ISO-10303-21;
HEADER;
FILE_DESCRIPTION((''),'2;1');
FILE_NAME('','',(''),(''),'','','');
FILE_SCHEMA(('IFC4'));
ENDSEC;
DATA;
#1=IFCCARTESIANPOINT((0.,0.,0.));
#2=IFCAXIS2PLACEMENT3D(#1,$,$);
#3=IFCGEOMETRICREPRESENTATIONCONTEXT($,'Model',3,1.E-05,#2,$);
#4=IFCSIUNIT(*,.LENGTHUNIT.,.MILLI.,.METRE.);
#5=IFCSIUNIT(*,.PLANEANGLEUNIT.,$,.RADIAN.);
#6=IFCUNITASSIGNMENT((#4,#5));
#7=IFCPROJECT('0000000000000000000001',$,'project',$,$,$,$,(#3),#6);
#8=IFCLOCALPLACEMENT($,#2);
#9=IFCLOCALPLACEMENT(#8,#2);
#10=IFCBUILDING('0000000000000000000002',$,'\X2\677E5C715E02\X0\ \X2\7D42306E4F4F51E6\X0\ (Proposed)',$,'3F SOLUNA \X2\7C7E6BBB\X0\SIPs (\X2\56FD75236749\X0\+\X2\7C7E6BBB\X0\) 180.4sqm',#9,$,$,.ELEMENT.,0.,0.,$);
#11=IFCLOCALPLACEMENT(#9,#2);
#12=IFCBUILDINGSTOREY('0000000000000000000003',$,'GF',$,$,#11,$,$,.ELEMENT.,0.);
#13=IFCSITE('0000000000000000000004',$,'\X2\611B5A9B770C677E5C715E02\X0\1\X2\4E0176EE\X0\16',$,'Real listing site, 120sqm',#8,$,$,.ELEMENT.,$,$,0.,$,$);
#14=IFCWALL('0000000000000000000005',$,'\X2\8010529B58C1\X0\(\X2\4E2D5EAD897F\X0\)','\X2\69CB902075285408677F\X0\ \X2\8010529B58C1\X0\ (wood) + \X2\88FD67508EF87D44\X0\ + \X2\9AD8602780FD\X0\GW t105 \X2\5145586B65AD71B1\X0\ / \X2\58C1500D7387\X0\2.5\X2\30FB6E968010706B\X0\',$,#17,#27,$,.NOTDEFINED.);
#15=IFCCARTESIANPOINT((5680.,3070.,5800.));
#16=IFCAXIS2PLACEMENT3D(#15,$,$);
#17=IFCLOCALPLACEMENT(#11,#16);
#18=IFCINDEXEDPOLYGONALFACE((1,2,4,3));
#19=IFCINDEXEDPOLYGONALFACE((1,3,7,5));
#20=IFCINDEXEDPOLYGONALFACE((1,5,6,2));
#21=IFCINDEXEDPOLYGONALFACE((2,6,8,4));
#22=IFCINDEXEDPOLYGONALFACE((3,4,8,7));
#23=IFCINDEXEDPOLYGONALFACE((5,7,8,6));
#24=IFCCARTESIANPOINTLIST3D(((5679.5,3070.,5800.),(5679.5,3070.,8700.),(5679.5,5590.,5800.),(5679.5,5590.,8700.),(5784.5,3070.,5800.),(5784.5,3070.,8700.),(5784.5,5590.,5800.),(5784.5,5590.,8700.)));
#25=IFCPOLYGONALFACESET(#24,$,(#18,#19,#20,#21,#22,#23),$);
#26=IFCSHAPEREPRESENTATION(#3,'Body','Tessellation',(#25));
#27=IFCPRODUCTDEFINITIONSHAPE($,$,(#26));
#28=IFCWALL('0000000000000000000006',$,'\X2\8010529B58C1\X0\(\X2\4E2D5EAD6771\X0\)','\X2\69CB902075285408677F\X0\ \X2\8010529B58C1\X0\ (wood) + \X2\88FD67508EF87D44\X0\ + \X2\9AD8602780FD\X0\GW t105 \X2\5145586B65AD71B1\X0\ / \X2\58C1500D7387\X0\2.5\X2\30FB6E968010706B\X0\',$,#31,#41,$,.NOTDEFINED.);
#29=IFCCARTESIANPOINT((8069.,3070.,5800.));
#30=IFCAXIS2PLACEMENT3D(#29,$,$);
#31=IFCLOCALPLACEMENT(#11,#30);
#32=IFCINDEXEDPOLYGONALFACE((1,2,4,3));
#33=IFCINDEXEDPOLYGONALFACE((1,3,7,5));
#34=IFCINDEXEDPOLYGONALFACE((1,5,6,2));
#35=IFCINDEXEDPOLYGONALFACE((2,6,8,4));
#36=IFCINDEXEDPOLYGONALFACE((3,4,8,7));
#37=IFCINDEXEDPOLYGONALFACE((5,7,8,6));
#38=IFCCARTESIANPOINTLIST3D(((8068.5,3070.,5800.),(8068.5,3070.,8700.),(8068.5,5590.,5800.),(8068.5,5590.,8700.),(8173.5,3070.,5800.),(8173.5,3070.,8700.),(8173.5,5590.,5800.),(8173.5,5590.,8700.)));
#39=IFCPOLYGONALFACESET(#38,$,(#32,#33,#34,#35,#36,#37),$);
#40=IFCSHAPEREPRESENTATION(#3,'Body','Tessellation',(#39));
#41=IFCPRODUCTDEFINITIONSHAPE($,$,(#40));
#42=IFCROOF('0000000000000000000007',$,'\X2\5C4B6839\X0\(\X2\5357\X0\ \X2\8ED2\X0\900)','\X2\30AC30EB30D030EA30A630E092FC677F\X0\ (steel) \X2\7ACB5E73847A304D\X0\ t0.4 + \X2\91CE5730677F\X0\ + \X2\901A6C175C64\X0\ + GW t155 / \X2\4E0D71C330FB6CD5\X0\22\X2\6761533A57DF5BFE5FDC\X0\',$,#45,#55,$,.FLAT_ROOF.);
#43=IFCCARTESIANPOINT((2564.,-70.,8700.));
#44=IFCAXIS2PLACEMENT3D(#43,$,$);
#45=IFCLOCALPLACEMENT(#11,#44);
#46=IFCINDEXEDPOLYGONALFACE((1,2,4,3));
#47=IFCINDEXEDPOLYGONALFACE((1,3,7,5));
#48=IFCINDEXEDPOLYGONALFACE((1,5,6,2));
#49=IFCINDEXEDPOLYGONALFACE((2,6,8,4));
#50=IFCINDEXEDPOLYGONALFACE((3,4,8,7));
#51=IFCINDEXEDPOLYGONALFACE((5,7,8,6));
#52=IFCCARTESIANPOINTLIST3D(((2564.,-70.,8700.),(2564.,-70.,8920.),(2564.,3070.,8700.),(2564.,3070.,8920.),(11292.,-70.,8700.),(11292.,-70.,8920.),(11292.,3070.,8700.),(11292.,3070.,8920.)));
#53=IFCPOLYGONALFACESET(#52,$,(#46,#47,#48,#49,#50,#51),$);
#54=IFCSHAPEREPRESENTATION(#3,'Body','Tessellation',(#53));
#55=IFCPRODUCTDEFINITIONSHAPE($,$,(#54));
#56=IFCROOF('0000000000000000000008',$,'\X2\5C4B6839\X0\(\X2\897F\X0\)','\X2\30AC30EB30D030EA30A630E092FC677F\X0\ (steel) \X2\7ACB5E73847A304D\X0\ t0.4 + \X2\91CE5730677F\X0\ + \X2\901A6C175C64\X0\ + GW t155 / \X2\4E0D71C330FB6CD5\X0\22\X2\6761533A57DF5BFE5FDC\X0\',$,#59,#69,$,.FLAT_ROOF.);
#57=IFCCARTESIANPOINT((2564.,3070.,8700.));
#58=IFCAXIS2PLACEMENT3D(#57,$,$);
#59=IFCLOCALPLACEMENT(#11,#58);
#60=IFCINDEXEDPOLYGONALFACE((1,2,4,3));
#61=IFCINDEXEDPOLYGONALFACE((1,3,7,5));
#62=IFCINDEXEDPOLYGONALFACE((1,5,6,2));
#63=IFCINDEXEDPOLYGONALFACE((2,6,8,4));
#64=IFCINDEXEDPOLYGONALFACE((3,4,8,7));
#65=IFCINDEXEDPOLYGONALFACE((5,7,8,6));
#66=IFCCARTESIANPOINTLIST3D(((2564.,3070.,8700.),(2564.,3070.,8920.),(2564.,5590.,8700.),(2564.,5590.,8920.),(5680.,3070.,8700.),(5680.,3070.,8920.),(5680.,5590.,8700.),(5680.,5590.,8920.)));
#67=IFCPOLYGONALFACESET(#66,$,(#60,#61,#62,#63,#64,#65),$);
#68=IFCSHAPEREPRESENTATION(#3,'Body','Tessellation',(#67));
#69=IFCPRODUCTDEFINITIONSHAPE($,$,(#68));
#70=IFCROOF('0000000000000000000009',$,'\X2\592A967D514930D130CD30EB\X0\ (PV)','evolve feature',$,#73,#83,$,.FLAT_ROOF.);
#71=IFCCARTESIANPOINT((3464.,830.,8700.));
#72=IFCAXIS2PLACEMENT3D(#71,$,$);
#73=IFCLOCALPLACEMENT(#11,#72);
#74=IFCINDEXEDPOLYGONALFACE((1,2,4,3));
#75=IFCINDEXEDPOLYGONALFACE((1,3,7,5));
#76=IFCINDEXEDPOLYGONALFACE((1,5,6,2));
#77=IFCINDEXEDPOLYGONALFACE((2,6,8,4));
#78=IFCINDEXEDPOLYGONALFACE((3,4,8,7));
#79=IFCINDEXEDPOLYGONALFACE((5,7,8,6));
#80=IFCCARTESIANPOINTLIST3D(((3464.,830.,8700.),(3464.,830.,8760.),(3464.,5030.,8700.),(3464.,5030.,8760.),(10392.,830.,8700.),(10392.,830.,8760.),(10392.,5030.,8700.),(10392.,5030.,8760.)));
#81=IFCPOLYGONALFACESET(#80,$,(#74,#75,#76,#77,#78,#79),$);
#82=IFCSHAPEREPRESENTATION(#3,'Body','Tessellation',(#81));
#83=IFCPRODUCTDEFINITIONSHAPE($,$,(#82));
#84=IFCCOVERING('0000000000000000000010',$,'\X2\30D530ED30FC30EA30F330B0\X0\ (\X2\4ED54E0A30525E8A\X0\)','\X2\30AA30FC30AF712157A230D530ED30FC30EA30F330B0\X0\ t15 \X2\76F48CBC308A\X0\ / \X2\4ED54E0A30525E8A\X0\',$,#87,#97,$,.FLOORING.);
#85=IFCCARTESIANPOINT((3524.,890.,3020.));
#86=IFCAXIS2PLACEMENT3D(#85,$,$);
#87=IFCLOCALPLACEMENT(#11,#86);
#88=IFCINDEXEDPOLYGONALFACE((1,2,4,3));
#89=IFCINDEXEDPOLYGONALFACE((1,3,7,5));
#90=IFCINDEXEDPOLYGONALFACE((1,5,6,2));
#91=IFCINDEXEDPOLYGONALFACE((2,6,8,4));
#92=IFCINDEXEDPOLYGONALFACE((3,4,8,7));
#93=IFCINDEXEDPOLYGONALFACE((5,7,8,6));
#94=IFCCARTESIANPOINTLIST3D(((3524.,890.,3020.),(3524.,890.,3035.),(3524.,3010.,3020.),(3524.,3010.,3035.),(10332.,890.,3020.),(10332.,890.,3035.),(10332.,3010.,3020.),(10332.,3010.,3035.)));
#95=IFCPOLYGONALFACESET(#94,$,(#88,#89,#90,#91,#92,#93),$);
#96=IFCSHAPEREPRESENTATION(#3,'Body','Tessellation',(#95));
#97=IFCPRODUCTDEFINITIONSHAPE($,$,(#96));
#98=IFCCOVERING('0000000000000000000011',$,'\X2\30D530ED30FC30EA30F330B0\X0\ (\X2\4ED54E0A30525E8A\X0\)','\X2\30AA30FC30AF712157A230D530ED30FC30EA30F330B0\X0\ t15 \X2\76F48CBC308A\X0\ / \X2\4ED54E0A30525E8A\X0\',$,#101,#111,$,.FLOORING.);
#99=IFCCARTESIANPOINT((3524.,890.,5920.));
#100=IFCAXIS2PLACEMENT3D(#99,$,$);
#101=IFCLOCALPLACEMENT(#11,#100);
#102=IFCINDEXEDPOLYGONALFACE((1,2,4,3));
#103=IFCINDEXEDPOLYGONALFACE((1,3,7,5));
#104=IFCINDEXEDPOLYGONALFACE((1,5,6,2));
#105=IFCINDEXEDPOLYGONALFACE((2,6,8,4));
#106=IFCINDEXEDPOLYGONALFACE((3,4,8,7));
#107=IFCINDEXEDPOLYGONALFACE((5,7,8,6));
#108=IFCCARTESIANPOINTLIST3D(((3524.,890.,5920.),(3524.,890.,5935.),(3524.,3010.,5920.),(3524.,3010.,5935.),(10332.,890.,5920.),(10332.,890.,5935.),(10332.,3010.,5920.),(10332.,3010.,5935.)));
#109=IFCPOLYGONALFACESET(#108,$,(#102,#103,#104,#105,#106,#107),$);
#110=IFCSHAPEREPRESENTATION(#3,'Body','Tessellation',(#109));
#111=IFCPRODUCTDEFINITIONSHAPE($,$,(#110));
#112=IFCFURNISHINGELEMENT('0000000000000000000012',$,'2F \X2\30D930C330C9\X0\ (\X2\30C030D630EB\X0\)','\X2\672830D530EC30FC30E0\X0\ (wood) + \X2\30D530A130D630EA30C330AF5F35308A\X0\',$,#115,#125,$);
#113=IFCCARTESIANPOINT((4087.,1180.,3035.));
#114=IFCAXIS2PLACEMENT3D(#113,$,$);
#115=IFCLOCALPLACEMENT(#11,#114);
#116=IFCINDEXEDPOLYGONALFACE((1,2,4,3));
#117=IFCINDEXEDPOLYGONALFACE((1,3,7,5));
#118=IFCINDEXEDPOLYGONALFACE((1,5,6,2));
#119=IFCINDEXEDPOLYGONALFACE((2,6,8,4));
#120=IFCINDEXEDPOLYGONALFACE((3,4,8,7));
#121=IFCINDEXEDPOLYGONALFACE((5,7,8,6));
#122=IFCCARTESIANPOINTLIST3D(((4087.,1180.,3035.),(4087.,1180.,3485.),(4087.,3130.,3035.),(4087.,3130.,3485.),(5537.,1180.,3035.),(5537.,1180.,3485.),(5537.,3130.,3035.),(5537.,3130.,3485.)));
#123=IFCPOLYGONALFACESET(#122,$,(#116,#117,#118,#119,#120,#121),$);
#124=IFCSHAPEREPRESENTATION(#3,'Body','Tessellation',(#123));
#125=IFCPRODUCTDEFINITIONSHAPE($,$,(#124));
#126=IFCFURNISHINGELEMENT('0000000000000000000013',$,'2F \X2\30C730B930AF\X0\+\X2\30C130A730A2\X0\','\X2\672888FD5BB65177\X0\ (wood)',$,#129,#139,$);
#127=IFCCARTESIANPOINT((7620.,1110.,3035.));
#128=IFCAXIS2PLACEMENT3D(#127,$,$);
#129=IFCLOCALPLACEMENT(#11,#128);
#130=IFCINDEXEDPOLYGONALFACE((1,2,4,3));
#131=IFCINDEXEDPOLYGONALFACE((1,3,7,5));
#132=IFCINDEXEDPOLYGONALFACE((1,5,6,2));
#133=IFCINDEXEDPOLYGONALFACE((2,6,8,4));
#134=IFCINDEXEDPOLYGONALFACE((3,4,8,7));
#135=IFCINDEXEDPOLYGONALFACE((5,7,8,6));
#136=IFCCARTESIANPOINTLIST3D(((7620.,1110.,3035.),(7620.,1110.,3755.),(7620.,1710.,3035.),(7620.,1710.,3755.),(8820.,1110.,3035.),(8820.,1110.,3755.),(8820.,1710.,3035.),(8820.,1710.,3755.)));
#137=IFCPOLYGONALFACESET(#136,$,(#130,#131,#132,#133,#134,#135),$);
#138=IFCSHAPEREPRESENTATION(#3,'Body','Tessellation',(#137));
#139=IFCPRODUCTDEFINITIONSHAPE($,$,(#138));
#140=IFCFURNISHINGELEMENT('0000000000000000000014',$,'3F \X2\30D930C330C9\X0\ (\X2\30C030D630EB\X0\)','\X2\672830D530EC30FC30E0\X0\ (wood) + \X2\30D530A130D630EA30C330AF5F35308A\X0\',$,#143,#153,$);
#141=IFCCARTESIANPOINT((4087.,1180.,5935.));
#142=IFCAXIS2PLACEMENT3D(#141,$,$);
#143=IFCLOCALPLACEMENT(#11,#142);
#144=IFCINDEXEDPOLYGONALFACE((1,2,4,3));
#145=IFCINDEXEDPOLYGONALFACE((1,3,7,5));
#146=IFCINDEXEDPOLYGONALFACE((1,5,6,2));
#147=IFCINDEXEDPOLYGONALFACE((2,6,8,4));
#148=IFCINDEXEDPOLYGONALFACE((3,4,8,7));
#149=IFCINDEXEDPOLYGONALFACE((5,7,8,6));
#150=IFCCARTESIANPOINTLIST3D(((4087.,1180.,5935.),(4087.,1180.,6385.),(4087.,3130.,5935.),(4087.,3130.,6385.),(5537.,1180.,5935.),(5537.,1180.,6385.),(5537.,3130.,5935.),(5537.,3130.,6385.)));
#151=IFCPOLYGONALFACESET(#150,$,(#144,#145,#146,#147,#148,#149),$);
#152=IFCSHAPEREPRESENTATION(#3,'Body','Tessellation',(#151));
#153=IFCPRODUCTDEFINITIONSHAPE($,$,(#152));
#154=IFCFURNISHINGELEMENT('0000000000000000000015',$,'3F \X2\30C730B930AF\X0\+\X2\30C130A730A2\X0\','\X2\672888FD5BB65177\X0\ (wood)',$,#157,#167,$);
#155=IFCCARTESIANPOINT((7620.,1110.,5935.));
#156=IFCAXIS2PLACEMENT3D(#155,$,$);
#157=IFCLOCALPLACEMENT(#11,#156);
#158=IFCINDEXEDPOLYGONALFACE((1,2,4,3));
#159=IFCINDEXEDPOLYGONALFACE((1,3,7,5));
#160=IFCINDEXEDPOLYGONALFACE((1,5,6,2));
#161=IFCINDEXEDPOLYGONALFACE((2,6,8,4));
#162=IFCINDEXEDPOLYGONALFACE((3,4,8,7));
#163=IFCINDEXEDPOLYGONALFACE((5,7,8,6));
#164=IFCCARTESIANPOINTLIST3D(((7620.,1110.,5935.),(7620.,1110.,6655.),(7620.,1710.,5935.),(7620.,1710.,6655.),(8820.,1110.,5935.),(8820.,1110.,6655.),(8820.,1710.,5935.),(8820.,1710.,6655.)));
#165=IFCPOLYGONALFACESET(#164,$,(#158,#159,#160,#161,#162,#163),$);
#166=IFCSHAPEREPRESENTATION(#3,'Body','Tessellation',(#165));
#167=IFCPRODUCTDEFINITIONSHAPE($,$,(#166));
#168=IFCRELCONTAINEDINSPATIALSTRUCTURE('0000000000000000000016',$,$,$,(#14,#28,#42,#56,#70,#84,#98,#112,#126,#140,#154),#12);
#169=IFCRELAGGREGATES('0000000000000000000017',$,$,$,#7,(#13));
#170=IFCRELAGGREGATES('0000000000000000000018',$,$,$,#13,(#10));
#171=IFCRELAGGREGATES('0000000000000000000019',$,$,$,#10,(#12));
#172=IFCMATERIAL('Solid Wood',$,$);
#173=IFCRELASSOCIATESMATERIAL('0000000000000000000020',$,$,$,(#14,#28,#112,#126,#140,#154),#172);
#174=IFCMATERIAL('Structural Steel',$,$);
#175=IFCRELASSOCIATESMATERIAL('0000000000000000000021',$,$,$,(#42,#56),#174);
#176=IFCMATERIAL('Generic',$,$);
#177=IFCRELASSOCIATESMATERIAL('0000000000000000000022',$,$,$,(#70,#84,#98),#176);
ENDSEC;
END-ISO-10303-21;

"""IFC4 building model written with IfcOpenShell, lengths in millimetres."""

from ifc_helpers import new_model, si_unit, frame, frame_2d, origin, place, context, project, spatial, rectangle, extrude, material, element, save


model = new_model("IFC4")

# Units and contexts
model_context = context("Model", 3, precision=1e-05, world=origin())
ifc_project = project(units=[si_unit("LENGTHUNIT", "METRE", prefix="MILLI"), si_unit("PLANEANGLEUNIT", "RADIAN")], contexts=[model_context])

# Site, building, storey
site_placement = place(None, origin())
site = spatial("IfcSite", under=ifc_project, at=site_placement, Name="愛媛県松山市1丁目16", ObjectType="Real listing site, 120sqm", CompositionType="ELEMENT", RefElevation=0.0)
building_placement = place(site_placement, origin())
building = spatial("IfcBuilding", under=site, at=building_placement, Name="松山市 終の住処 (Proposed)", ObjectType="3F SOLUNA 籾殻SIPs (国産杉+籾殻) 180.4sqm", CompositionType="ELEMENT", ElevationOfRefHeight=0.0, ElevationOfTerrain=0.0)
storey_placement = place(building_placement, origin())
storey = spatial("IfcBuildingStorey", under=building, at=storey_placement, Name="GF", CompositionType="ELEMENT", Elevation=0.0)

# Shared definitions
ifc_material_1 = material(Name="Solid Wood")

# Walls
wall_1_placement = place(storey_placement, frame((5680.0, 3070.0, 5800.0)))
element("IfcWall", 1, at=wall_1_placement, inside=storey, material=ifc_material_1, Name="耐力壁(中庭西)", Description="構造用合板 耐力壁 (wood) + 製材軸組 + 高性能GW t105 充填断熱 / 壁倍率2.5・準耐火", PredefinedType="NOTDEFINED", context=model_context, shape_type="SweptSolid", body=[
    extrude(rectangle(XDim=105.0, YDim=2520.0, at=frame_2d((52.0, 1260.0))), frame((5680.0, 3070.0, 5800.0)), (0.0, 0.0, 1.0), 2900.0),
])
wall_2_placement = place(storey_placement, frame((8069.0, 3070.0, 5800.0)))
element("IfcWall", 2, at=wall_2_placement, inside=storey, material=ifc_material_1, Name="耐力壁(中庭東)", Description="構造用合板 耐力壁 (wood) + 製材軸組 + 高性能GW t105 充填断熱 / 壁倍率2.5・準耐火", PredefinedType="NOTDEFINED", context=model_context, shape_type="SweptSolid", body=[
    extrude(rectangle(XDim=105.0, YDim=2520.0, at=frame_2d((52.0, 1260.0))), frame((8069.0, 3070.0, 5800.0)), (0.0, 0.0, 1.0), 2900.0),
])

# Roofs
ifc_material_2 = material(Name="Structural Steel")
roof_1_placement = place(storey_placement, frame((2564.0, -70.0, 8700.0)))
element("IfcRoof", 3, at=roof_1_placement, inside=storey, material=ifc_material_2, Name="屋根(南 軒900)", Description="ガルバリウム鋼板 (steel) 立平葺き t0.4 + 野地板 + 通気層 + GW t155 / 不燃・法22条区域対応", PredefinedType="FLAT_ROOF", context=model_context, shape_type="SweptSolid", body=[
    extrude(rectangle(XDim=8728.0, YDim=3140.0, at=frame_2d((4364.0, 1570.0))), frame((2564.0, -70.0, 8700.0)), (0.0, 0.0, 1.0), 220.0),
])
roof_2_placement = place(storey_placement, frame((2564.0, 3070.0, 8700.0)))
element("IfcRoof", 4, at=roof_2_placement, inside=storey, material=ifc_material_2, Name="屋根(西)", Description="ガルバリウム鋼板 (steel) 立平葺き t0.4 + 野地板 + 通気層 + GW t155 / 不燃・法22条区域対応", PredefinedType="FLAT_ROOF", context=model_context, shape_type="SweptSolid", body=[
    extrude(rectangle(XDim=3116.0, YDim=2520.0, at=frame_2d((1558.0, 1260.0))), frame((2564.0, 3070.0, 8700.0)), (0.0, 0.0, 1.0), 220.0),
])
ifc_material_3 = material(Name="Generic")
roof_3_placement = place(storey_placement, frame((3464.0, 830.0, 8700.0)))
element("IfcRoof", 5, at=roof_3_placement, inside=storey, material=ifc_material_3, Name="太陽光パネル (PV)", Description="evolve feature", PredefinedType="FLAT_ROOF", context=model_context, shape_type="SweptSolid", body=[
    extrude(rectangle(XDim=6928.0, YDim=4200.0, at=frame_2d((3464.0, 2100.0))), frame((3464.0, 830.0, 8700.0)), (0.0, 0.0, 1.0), 60.0),
])

# Coverings
covering_1_placement = place(storey_placement, frame((3524.0, 890.0, 3020.0)))
element("IfcCovering", 6, at=covering_1_placement, inside=storey, material=ifc_material_3, Name="フローリング (仕上げ床)", Description="オーク無垢フローリング t15 直貼り / 仕上げ床", PredefinedType="FLOORING", context=model_context, shape_type="SweptSolid", body=[
    extrude(rectangle(XDim=6808.0, YDim=2120.0, at=frame_2d((3404.0, 1060.0))), frame((3524.0, 890.0, 3020.0)), (0.0, 0.0, 1.0), 15.0),
])
covering_2_placement = place(storey_placement, frame((3524.0, 890.0, 5920.0)))
element("IfcCovering", 7, at=covering_2_placement, inside=storey, material=ifc_material_3, Name="フローリング (仕上げ床)", Description="オーク無垢フローリング t15 直貼り / 仕上げ床", PredefinedType="FLOORING", context=model_context, shape_type="SweptSolid", body=[
    extrude(rectangle(XDim=6808.0, YDim=2120.0, at=frame_2d((3404.0, 1060.0))), frame((3524.0, 890.0, 5920.0)), (0.0, 0.0, 1.0), 15.0),
])

# Furnishing elements
furnishing_1_placement = place(storey_placement, frame((4087.0, 1180.0, 3035.0)))
element("IfcFurnishingElement", 8, at=furnishing_1_placement, inside=storey, material=ifc_material_1, Name="2F ベッド (ダブル)", Description="木フレーム (wood) + ファブリック張り", context=model_context, shape_type="SweptSolid", body=[
    extrude(rectangle(XDim=1450.0, YDim=1950.0, at=frame_2d((725.0, 975.0))), frame((4087.0, 1180.0, 3035.0)), (0.0, 0.0, 1.0), 450.0),
])
furnishing_2_placement = place(storey_placement, frame((7620.0, 1110.0, 3035.0)))
element("IfcFurnishingElement", 9, at=furnishing_2_placement, inside=storey, material=ifc_material_1, Name="2F デスク+チェア", Description="木製家具 (wood)", context=model_context, shape_type="SweptSolid", body=[
    extrude(rectangle(XDim=1200.0, YDim=600.0, at=frame_2d((600.0, 300.0))), frame((7620.0, 1110.0, 3035.0)), (0.0, 0.0, 1.0), 720.0),
])
furnishing_3_placement = place(storey_placement, frame((4087.0, 1180.0, 5935.0)))
element("IfcFurnishingElement", 10, at=furnishing_3_placement, inside=storey, material=ifc_material_1, Name="3F ベッド (ダブル)", Description="木フレーム (wood) + ファブリック張り", context=model_context, shape_type="SweptSolid", body=[
    extrude(rectangle(XDim=1450.0, YDim=1950.0, at=frame_2d((725.0, 975.0))), frame((4087.0, 1180.0, 5935.0)), (0.0, 0.0, 1.0), 450.0),
])
furnishing_4_placement = place(storey_placement, frame((7620.0, 1110.0, 5935.0)))
element("IfcFurnishingElement", 11, at=furnishing_4_placement, inside=storey, material=ifc_material_1, Name="3F デスク+チェア", Description="木製家具 (wood)", context=model_context, shape_type="SweptSolid", body=[
    extrude(rectangle(XDim=1200.0, YDim=600.0, at=frame_2d((600.0, 300.0))), frame((7620.0, 1110.0, 5935.0)), (0.0, 0.0, 1.0), 720.0),
])

save(model, "model.ifc")
